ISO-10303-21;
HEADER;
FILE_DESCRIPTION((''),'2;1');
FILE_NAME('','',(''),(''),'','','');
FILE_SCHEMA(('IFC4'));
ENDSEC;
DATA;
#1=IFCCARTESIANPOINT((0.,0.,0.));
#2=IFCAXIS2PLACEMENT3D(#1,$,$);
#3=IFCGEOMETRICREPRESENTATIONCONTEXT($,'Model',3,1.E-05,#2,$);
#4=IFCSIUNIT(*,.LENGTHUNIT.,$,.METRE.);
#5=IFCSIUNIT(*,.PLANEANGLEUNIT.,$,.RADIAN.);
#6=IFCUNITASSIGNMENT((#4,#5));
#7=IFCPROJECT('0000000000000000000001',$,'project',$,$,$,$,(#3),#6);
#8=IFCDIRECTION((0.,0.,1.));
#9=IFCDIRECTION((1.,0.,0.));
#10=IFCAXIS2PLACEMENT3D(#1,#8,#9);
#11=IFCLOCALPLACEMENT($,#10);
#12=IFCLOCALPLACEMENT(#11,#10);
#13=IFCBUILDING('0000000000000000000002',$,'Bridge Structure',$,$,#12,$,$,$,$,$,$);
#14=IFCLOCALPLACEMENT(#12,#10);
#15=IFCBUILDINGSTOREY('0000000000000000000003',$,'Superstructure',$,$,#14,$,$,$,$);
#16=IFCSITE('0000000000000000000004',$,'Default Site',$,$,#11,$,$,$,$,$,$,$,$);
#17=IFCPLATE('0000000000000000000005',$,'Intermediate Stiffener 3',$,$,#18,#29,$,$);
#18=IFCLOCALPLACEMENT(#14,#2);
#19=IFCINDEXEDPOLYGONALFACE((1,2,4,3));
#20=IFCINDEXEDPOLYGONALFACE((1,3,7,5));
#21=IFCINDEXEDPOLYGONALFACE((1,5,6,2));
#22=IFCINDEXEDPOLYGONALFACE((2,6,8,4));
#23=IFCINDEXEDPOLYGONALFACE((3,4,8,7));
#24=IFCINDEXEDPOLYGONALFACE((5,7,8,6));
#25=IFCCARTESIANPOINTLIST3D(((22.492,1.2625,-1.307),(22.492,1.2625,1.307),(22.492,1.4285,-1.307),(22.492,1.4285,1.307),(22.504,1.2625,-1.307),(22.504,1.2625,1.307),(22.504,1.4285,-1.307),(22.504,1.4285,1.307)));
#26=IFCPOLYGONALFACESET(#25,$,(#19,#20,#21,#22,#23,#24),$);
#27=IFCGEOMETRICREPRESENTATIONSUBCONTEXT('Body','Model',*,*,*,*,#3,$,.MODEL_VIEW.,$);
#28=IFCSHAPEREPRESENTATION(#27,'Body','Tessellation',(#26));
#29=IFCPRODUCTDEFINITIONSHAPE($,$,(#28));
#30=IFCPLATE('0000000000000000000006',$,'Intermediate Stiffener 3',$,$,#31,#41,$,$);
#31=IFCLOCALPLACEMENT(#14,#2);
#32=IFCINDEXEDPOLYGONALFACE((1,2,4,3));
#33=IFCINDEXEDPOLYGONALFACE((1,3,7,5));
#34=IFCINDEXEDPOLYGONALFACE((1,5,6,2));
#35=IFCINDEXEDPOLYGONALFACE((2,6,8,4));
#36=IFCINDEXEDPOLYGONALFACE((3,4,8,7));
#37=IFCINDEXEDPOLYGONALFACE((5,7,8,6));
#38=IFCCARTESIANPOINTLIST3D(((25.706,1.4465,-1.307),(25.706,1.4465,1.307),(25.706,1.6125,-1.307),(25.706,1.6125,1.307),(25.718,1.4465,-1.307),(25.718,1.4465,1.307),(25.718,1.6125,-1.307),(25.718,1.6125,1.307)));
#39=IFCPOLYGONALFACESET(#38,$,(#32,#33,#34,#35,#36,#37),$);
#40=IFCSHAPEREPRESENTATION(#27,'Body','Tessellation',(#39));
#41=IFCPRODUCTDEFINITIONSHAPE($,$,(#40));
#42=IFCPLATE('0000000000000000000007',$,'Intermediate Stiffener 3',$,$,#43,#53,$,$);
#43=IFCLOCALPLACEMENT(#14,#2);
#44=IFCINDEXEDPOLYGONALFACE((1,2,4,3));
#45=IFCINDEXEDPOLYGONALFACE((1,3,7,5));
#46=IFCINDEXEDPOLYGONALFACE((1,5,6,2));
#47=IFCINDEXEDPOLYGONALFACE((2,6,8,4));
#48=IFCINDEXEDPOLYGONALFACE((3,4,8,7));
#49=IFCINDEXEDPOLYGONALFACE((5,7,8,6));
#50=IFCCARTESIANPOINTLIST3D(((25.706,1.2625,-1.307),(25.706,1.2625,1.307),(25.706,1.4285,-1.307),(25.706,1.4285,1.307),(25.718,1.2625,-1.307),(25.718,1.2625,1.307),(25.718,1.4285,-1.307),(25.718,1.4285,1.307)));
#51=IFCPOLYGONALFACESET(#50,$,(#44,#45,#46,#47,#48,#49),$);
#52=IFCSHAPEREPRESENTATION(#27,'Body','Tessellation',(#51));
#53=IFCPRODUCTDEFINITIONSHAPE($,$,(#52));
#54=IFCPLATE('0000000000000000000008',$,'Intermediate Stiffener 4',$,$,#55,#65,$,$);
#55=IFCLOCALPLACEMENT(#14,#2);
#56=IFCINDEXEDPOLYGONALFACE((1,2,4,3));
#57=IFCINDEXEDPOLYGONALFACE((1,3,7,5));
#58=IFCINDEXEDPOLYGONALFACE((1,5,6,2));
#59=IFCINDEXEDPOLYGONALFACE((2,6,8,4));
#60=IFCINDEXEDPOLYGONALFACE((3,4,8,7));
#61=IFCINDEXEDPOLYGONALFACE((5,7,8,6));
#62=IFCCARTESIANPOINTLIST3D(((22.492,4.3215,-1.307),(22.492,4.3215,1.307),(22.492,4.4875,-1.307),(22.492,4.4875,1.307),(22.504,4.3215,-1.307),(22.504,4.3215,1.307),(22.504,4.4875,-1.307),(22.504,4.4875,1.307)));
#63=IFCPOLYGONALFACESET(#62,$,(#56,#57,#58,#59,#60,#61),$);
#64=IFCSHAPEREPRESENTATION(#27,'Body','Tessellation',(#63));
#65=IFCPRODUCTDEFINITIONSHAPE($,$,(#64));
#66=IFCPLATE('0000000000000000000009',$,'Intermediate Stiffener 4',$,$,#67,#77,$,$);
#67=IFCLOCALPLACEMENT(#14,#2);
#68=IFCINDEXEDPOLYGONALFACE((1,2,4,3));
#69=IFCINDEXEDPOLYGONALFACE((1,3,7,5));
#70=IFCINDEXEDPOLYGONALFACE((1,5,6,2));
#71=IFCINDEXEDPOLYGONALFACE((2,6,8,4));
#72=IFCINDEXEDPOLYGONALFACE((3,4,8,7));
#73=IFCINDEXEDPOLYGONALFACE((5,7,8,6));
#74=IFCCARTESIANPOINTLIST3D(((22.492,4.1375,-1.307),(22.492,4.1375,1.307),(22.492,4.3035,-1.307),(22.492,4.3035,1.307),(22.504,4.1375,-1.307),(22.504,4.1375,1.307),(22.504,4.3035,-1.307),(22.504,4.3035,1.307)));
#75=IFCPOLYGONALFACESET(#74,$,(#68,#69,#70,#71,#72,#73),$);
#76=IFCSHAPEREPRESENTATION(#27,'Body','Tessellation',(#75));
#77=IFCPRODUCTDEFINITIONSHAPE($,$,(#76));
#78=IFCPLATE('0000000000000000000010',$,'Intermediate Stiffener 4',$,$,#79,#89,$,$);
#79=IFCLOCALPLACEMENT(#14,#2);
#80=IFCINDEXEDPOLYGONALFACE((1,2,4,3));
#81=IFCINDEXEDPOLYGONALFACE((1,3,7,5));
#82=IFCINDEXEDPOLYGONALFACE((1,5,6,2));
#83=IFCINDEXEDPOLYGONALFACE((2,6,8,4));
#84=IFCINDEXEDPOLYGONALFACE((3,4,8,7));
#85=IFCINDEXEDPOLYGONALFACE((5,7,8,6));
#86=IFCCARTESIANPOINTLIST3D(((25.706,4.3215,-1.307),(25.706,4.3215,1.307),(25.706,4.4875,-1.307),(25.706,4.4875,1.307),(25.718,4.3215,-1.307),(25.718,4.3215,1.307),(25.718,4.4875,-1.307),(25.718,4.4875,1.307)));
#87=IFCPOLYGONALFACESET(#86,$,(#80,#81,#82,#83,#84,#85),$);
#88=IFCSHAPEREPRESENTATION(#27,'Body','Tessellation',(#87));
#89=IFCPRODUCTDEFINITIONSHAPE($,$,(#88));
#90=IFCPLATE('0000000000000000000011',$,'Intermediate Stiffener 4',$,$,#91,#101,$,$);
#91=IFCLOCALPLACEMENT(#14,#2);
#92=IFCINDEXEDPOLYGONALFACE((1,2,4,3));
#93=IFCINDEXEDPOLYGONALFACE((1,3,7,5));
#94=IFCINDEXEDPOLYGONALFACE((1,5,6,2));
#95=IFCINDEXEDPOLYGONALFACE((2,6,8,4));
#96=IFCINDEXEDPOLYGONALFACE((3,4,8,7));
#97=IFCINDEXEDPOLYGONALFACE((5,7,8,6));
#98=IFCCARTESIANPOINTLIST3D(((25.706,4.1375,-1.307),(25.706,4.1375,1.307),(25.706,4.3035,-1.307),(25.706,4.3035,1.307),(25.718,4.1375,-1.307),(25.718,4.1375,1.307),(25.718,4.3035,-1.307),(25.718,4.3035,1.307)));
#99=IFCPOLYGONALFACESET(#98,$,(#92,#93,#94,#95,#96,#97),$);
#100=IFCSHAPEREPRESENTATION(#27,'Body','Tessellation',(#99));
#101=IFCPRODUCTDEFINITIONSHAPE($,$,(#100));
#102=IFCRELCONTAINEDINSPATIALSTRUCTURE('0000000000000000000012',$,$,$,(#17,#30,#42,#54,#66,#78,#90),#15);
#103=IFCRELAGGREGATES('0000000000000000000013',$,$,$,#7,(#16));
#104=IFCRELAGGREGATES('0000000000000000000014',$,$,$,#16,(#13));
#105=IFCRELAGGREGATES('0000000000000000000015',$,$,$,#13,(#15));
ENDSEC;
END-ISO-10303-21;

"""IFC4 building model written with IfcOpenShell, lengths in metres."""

from ifc_helpers import new_model, si_unit, frame, origin, origin_with_axes, origin_2d_with_axis, place, context, subcontext, project, spatial, rectangle, extrude, element, save


model = new_model("IFC4")

# Units and contexts
model_context = context("Model", 3, precision=1e-05, world=origin())
body_context = subcontext(model_context, "Body", "Model", "MODEL_VIEW")
ifc_project = project(units=[si_unit("LENGTHUNIT", "METRE"), si_unit("PLANEANGLEUNIT", "RADIAN")], contexts=[model_context])

# Site, building, storey
site_placement = place(None, origin_with_axes())
site = spatial("IfcSite", under=ifc_project, at=site_placement, Name="Default Site")
building_placement = place(site_placement, origin_with_axes())
building = spatial("IfcBuilding", under=site, at=building_placement, Name="Bridge Structure")
storey_placement = place(building_placement, origin_with_axes())
storey = spatial("IfcBuildingStorey", under=building, at=storey_placement, Name="Superstructure")

# Plates
for number, where, z_axis, x_axis, name in (
    (1, (22.498, 1.3455, -1.307), (0.0, 0.0, 1.0), (1.0, 0.0, 0.0), "Intermediate Stiffener 3"),
    (2, (25.712, 1.5295, -1.307), (0.0, 0.0, 1.0), (1.0, 0.0, 0.0), "Intermediate Stiffener 3"),
    (3, (25.712, 1.3455, -1.307), (0.0, 0.0, 1.0), (1.0, 0.0, 0.0), "Intermediate Stiffener 3"),
    (4, (22.498, 4.4045, -1.307), (0.0, 0.0, 1.0), (1.0, 0.0, 0.0), "Intermediate Stiffener 4"),
    (5, (22.498, 4.2205, -1.307), (0.0, 0.0, 1.0), (1.0, 0.0, 0.0), "Intermediate Stiffener 4"),
    (6, (25.712, 4.4045, -1.307), (0.0, 0.0, 1.0), (1.0, 0.0, 0.0), "Intermediate Stiffener 4"),
    (7, (25.712, 4.2205, -1.307), (0.0, 0.0, 1.0), (1.0, 0.0, 0.0), "Intermediate Stiffener 4"),
):
    element("IfcPlate", number, at=place(storey_placement, frame(where, z_axis=z_axis, x_axis=x_axis)), inside=storey, Name=name, context=body_context, shape_type="SweptSolid", body=[
        extrude(rectangle(XDim=0.012, YDim=0.166, at=origin_2d_with_axis()), origin_with_axes(), (0.0, 0.0, 1.0), 2.614),
    ])

save(model, "model.ifc")
